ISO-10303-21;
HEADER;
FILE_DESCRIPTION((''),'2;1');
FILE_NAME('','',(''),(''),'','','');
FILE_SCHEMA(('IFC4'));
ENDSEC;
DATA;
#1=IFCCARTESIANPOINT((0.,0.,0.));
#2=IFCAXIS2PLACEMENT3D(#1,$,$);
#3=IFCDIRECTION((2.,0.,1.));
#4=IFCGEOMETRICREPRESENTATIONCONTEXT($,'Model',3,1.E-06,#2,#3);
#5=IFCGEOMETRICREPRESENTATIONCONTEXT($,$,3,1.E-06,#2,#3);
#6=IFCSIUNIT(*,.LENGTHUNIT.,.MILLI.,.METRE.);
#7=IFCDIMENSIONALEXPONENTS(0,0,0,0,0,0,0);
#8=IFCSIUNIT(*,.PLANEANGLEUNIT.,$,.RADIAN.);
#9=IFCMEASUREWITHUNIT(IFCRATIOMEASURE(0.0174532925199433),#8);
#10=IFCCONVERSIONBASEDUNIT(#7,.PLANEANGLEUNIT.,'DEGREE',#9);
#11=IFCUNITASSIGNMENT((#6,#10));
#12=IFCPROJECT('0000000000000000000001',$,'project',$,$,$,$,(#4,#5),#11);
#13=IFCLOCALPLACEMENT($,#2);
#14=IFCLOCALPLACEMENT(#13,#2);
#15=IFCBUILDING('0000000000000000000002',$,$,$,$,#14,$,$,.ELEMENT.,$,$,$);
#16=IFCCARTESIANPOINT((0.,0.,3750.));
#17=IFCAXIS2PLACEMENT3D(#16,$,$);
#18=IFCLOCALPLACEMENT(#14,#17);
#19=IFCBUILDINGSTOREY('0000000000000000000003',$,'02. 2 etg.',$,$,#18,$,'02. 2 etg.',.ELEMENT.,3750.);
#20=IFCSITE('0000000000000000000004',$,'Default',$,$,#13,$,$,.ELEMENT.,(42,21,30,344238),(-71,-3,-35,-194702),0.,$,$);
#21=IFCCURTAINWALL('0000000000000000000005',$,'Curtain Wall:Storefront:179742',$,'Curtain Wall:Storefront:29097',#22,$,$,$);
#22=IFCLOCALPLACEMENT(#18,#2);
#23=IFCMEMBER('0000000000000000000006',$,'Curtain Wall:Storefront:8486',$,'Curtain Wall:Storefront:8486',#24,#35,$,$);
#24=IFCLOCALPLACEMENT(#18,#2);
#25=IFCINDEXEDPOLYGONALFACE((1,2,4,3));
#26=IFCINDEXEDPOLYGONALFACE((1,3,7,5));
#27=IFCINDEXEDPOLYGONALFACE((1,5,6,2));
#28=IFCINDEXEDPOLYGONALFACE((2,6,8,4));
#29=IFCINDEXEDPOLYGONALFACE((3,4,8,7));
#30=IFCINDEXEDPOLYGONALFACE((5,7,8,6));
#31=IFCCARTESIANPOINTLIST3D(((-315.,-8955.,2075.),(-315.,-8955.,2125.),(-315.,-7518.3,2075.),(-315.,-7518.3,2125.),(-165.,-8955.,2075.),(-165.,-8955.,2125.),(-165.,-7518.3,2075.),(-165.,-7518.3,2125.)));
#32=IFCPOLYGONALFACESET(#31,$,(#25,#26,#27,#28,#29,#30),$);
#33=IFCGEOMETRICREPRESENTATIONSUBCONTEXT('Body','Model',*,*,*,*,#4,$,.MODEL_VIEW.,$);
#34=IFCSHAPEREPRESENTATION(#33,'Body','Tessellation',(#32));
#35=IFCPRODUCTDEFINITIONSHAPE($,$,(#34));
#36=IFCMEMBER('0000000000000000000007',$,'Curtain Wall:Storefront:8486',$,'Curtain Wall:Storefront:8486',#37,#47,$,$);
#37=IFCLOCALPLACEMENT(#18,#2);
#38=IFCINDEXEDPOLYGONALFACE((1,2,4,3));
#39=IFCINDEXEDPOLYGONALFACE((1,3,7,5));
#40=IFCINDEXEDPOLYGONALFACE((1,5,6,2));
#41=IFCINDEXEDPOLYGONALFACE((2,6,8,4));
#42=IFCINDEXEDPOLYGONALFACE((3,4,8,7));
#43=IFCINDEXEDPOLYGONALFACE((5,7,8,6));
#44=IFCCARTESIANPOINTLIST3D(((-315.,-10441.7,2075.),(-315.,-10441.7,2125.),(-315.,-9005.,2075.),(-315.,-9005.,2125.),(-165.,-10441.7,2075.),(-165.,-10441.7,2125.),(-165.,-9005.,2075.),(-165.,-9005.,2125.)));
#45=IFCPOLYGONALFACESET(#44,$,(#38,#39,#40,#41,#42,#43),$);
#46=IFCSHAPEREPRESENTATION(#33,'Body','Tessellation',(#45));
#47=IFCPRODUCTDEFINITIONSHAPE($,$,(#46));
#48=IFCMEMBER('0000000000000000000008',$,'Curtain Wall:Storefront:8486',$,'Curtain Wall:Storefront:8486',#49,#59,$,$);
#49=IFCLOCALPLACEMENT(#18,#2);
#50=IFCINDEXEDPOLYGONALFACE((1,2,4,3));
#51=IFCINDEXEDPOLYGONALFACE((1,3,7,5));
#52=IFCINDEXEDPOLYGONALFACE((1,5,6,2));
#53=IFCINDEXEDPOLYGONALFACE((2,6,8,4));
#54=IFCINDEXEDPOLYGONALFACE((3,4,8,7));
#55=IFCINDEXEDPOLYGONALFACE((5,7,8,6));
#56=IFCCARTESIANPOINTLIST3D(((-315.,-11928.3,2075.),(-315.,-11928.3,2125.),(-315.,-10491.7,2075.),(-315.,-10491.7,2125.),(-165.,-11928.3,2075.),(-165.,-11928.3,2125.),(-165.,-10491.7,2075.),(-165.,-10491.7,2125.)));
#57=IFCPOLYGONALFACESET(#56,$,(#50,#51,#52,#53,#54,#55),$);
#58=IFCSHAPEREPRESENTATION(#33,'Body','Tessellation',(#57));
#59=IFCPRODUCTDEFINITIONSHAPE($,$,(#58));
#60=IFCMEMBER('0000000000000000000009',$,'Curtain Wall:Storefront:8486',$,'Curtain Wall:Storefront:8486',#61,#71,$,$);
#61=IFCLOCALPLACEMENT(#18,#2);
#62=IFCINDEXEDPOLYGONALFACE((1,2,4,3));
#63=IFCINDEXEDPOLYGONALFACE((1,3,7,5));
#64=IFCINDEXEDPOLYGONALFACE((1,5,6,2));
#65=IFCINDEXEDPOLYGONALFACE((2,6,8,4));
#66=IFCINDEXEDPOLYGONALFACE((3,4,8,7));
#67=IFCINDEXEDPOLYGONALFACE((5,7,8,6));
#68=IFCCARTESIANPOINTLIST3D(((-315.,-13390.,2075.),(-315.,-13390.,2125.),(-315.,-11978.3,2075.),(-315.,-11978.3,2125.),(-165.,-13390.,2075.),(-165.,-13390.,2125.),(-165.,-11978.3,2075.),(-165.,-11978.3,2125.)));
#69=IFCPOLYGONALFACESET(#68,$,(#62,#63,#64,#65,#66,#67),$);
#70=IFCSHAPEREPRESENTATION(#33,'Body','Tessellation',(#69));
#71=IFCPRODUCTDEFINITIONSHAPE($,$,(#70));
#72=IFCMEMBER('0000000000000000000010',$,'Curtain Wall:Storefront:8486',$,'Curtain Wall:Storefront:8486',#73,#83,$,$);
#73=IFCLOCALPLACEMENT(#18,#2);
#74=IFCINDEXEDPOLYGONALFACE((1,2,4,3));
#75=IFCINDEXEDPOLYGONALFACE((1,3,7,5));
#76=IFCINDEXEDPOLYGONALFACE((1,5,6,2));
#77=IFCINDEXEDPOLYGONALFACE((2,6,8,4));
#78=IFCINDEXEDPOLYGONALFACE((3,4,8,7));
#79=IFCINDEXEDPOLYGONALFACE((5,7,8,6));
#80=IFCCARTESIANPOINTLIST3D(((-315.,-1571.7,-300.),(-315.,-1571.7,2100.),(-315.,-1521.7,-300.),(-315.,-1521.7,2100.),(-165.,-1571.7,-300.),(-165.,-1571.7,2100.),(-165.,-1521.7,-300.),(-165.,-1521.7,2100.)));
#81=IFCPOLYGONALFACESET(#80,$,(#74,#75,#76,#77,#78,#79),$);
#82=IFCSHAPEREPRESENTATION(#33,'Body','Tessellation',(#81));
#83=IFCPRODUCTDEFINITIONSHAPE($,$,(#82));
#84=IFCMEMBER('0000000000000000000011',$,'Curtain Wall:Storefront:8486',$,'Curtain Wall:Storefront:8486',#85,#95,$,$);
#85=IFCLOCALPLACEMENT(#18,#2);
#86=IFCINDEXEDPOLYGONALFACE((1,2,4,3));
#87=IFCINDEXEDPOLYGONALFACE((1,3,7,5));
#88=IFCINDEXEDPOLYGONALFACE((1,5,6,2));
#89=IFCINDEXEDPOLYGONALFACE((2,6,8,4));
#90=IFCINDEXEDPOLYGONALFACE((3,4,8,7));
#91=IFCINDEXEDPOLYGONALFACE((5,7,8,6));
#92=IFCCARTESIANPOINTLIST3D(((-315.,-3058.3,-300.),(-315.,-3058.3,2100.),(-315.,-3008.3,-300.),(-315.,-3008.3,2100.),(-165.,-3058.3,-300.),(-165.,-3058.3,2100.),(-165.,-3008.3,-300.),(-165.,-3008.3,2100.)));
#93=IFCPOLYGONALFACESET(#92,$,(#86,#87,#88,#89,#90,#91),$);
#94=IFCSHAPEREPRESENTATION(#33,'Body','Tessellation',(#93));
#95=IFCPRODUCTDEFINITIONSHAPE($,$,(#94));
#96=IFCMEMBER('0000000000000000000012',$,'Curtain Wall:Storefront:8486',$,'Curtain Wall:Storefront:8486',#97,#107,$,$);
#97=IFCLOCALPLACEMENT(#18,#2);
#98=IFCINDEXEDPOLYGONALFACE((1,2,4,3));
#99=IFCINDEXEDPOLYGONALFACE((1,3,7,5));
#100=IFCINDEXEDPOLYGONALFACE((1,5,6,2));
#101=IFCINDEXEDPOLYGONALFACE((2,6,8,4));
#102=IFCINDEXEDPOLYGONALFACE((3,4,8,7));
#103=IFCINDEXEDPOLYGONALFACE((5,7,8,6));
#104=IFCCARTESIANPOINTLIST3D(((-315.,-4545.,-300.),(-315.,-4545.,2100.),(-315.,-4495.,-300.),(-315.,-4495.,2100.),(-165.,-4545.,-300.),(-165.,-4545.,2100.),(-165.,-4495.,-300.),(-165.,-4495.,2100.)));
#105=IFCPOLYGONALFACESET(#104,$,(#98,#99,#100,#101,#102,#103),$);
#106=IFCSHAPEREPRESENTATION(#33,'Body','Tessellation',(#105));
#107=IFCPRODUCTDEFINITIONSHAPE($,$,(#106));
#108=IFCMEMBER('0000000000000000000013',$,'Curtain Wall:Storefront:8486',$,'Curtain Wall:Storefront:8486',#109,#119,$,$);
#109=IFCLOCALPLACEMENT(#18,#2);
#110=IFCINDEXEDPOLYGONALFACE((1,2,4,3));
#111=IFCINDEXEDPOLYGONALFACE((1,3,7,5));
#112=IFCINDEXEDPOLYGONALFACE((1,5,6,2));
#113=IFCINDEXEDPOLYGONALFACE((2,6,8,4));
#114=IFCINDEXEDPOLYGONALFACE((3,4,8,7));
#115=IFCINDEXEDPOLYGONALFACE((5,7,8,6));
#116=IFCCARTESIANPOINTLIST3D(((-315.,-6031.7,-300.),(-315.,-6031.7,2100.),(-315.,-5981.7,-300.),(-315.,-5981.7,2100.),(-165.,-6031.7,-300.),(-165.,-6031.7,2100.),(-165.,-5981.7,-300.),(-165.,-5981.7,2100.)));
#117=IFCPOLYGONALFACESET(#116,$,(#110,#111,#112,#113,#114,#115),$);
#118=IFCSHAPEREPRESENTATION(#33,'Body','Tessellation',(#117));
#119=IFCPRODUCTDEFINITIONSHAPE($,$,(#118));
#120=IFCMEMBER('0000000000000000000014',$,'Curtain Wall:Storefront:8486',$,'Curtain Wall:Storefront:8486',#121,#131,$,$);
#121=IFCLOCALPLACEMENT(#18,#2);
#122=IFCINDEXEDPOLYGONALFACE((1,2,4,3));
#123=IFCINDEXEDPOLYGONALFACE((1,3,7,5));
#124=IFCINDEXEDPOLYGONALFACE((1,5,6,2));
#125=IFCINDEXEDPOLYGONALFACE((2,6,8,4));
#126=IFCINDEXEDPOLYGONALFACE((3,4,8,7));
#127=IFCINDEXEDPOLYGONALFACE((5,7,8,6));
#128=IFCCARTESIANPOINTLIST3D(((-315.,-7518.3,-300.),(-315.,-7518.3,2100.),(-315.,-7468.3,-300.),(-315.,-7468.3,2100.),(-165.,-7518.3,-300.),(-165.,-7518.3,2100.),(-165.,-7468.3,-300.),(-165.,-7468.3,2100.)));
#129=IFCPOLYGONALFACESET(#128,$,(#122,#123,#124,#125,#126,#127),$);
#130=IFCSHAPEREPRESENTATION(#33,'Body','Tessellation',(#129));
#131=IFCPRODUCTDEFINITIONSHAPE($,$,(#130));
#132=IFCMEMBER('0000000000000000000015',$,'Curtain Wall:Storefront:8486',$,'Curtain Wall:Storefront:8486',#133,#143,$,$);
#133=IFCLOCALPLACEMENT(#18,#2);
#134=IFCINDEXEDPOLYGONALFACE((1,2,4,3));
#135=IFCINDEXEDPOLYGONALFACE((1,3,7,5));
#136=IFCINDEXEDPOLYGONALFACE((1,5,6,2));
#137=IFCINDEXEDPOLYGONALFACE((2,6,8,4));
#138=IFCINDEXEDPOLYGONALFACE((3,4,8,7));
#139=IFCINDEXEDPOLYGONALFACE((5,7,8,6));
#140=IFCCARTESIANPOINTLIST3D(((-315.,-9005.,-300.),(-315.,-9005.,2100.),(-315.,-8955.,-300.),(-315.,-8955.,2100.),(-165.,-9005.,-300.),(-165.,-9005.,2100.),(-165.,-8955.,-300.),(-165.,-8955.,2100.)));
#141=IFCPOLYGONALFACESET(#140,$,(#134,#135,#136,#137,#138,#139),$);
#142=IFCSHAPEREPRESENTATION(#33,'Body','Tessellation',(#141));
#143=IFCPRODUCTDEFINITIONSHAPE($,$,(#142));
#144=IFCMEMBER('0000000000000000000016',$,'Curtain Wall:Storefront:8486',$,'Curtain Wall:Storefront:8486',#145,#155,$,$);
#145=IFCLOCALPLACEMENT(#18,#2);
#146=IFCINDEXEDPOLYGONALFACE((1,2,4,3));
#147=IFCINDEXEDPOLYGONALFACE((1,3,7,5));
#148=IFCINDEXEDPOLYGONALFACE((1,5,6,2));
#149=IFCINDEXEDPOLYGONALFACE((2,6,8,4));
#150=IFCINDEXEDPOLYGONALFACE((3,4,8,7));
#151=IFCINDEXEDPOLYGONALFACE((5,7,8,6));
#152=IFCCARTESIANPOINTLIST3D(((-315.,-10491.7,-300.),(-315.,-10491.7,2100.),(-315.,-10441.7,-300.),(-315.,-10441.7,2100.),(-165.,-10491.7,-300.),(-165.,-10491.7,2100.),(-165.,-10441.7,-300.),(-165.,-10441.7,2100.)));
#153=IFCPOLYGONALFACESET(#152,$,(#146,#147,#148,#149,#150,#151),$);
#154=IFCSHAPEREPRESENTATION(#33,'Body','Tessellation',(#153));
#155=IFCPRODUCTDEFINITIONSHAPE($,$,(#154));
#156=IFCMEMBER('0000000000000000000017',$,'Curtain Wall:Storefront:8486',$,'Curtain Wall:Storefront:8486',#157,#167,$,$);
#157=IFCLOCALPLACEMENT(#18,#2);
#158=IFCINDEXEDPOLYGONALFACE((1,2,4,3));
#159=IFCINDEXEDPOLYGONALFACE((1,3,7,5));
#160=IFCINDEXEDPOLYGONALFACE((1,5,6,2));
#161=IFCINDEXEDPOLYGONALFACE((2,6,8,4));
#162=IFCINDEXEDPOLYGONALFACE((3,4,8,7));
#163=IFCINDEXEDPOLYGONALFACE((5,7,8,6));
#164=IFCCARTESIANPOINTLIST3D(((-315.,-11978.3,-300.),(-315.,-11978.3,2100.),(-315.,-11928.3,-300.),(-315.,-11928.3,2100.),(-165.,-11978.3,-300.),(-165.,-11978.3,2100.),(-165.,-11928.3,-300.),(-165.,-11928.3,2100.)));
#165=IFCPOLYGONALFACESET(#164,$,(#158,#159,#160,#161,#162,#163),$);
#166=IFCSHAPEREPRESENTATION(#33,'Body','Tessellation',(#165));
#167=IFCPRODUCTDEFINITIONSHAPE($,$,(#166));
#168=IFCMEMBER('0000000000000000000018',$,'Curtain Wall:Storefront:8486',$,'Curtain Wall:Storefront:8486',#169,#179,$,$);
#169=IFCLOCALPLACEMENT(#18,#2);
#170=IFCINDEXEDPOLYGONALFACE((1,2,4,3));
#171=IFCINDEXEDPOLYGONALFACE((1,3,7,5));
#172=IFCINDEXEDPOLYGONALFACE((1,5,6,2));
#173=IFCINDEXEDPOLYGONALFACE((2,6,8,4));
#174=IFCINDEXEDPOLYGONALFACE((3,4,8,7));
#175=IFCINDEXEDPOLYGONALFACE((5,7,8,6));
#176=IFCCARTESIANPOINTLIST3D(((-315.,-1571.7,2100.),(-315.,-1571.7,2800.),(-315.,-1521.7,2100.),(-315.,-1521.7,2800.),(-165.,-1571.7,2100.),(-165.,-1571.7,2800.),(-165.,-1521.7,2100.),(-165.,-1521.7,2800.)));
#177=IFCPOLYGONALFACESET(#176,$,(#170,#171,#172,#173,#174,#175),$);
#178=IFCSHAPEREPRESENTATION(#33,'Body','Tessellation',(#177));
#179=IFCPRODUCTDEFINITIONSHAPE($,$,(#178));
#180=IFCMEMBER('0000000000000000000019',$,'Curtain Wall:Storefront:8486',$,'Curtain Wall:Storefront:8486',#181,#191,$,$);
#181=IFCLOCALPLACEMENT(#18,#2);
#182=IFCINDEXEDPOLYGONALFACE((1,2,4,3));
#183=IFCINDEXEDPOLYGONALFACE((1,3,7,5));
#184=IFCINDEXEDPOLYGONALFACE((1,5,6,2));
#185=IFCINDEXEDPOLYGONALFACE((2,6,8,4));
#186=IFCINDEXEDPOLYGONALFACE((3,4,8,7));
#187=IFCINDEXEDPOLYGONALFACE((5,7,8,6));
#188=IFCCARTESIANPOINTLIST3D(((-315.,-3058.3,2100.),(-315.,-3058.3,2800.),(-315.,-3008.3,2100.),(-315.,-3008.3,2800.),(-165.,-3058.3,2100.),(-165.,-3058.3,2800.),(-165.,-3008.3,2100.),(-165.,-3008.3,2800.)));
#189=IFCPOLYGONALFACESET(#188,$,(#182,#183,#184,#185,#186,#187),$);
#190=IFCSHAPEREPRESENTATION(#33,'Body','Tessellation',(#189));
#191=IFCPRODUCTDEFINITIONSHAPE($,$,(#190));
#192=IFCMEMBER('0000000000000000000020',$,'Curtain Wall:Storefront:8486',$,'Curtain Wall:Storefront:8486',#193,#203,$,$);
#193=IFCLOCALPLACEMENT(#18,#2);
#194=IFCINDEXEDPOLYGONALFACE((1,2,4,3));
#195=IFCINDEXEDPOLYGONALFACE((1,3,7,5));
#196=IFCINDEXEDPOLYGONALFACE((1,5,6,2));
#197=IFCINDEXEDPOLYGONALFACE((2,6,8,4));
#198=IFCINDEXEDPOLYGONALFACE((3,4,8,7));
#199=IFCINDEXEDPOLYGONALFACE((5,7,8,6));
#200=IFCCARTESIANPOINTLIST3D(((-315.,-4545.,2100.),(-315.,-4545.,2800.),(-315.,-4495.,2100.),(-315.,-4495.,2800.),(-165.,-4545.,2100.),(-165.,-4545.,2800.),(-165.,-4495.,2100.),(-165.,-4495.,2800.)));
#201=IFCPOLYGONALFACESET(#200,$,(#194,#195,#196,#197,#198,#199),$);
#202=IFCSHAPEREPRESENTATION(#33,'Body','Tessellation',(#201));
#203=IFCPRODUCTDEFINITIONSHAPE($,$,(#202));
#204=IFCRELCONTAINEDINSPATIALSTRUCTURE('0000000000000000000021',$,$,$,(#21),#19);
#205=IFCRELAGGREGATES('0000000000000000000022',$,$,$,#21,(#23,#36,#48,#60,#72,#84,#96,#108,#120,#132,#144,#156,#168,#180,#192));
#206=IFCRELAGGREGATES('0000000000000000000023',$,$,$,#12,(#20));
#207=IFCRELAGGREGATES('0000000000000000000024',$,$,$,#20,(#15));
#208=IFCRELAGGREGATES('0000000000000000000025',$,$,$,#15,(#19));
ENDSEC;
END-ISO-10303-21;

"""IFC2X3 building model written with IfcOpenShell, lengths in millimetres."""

from ifc_helpers import new_model, entity, si_unit, converted_unit, direction, frame, frame_2d, origin, origin_2d_with_axis, place, context, subcontext, project, spatial, rectangle, extrude, element, aggregate, save


model = new_model("IFC2X3")

# Units and contexts
model_context = context("Model", 3, precision=1e-06, world=origin(), true_north=direction((2.0, 0.0, 1.0)))
context_of_model = context(None, 3, precision=1e-06, world=origin(), true_north=direction((2.0, 0.0, 1.0)))
body_context = subcontext(model_context, "Body", "Model", "MODEL_VIEW")
ifc_project = project(units=[si_unit("LENGTHUNIT", "METRE", prefix="MILLI"), converted_unit("PLANEANGLEUNIT", "DEGREE", entity("IfcRatioMeasure", 0.0174532925199433), si_unit("PLANEANGLEUNIT", "RADIAN"), dimensions=[0, 0, 0, 0, 0, 0, 0])], contexts=[model_context, context_of_model])

# Site, building, storey
site_placement = place(None, origin())
site = spatial("IfcSite", under=ifc_project, at=site_placement, Name="Default", CompositionType="ELEMENT", RefLatitude=(42, 21, 30, 344238), RefLongitude=(-71, -3, -35, -194702), RefElevation=0.0)
building_placement = place(site_placement, origin())
building = spatial("IfcBuilding", under=site, at=building_placement, CompositionType="ELEMENT")
storey_placement = place(building_placement, frame((0.0, 0.0, 3750.0)))
storey = spatial("IfcBuildingStorey", under=building, at=storey_placement, Name="02. 2 etg.", LongName="02. 2 etg.", CompositionType="ELEMENT", Elevation=3750.0)

# Curtain wall, members
curtain_wall_1_placement = place(storey_placement, origin())
curtain_wall_1 = element("IfcCurtainWall", 1, at=curtain_wall_1_placement, inside=storey, Name="Curtain Wall:Storefront:179742", ObjectType="Curtain Wall:Storefront:29097")
member_1_placement = place(storey_placement, origin())
member_1 = element("IfcMember", 2, at=member_1_placement, Name="Curtain Wall:Storefront:8486", ObjectType="Curtain Wall:Storefront:8486", context=body_context, shape_type="SweptSolid", body=[
    extrude(rectangle(XDim=1436.7, YDim=150.0, at=frame_2d((0.0, 0.0), x_axis=(1.0, 0.0))), frame((-240.0, -8236.7, 2075.0), z_axis=(0.0, 0.0, 1.0), x_axis=(0.0, 1.0, 0.0)), (0.0, 0.0, 1.0), 50.0),
])
member_2_placement = place(storey_placement, origin())
member_2 = element("IfcMember", 3, at=member_2_placement, Name="Curtain Wall:Storefront:8486", ObjectType="Curtain Wall:Storefront:8486", context=body_context, shape_type="SweptSolid", body=[
    extrude(rectangle(XDim=1436.7, YDim=150.0, at=origin_2d_with_axis()), frame((-240.0, -9723.3, 2075.0), z_axis=(0.0, 0.0, 1.0), x_axis=(0.0, 1.0, 0.0)), (0.0, 0.0, 1.0), 50.0),
])
member_3_placement = place(storey_placement, origin())
member_3 = element("IfcMember", 4, at=member_3_placement, Name="Curtain Wall:Storefront:8486", ObjectType="Curtain Wall:Storefront:8486", context=body_context, shape_type="SweptSolid", body=[
    extrude(rectangle(XDim=1436.7, YDim=150.0, at=origin_2d_with_axis()), frame((-240.0, -11210.0, 2075.0), z_axis=(0.0, 0.0, 1.0), x_axis=(0.0, 1.0, 0.0)), (0.0, 0.0, 1.0), 50.0),
])
member_4_placement = place(storey_placement, origin())
member_4 = element("IfcMember", 5, at=member_4_placement, Name="Curtain Wall:Storefront:8486", ObjectType="Curtain Wall:Storefront:8486", context=body_context, shape_type="SweptSolid", body=[
    extrude(rectangle(XDim=1411.7, YDim=150.0, at=frame_2d((0.0, 0.0), x_axis=(1.0, 0.0))), frame((-240.0, -12684.2, 2075.0), z_axis=(0.0, 0.0, 1.0), x_axis=(0.0, 1.0, 0.0)), (0.0, 0.0, 1.0), 50.0),
])
member_5_placement = place(storey_placement, origin())
member_5 = element("IfcMember", 6, at=member_5_placement, Name="Curtain Wall:Storefront:8486", ObjectType="Curtain Wall:Storefront:8486", context=body_context, shape_type="SweptSolid", body=[
    extrude(rectangle(XDim=150.0, YDim=50.0, at=frame_2d((0.0, 0.0), x_axis=(1.0, 0.0))), frame((-240.0, -1546.7, -300.0)), (0.0, 0.0, 1.0), 2400.0),
])
member_6_placement = place(storey_placement, origin())
member_6 = element("IfcMember", 7, at=member_6_placement, Name="Curtain Wall:Storefront:8486", ObjectType="Curtain Wall:Storefront:8486", context=body_context, shape_type="SweptSolid", body=[
    extrude(rectangle(XDim=150.0, YDim=50.0, at=frame_2d((0.0, 0.0), x_axis=(1.0, 0.0))), frame((-240.0, -3033.3, -300.0)), (0.0, 0.0, 1.0), 2400.0),
])
member_7_placement = place(storey_placement, origin())
member_7 = element("IfcMember", 8, at=member_7_placement, Name="Curtain Wall:Storefront:8486", ObjectType="Curtain Wall:Storefront:8486", context=body_context, shape_type="SweptSolid", body=[
    extrude(rectangle(XDim=150.0, YDim=50.0, at=frame_2d((0.0, 0.0), x_axis=(1.0, 0.0))), frame((-240.0, -4520.0, -300.0)), (0.0, 0.0, 1.0), 2400.0),
])
member_8_placement = place(storey_placement, origin())
member_8 = element("IfcMember", 9, at=member_8_placement, Name="Curtain Wall:Storefront:8486", ObjectType="Curtain Wall:Storefront:8486", context=body_context, shape_type="SweptSolid", body=[
    extrude(rectangle(XDim=150.0, YDim=50.0, at=frame_2d((0.0, 0.0), x_axis=(1.0, 0.0))), frame((-240.0, -6006.7, -300.0)), (0.0, 0.0, 1.0), 2400.0),
])
member_9_placement = place(storey_placement, origin())
member_9 = element("IfcMember", 10, at=member_9_placement, Name="Curtain Wall:Storefront:8486", ObjectType="Curtain Wall:Storefront:8486", context=body_context, shape_type="SweptSolid", body=[
    extrude(rectangle(XDim=150.0, YDim=50.0, at=frame_2d((0.0, 0.0), x_axis=(1.0, 0.0))), frame((-240.0, -7493.3, -300.0)), (0.0, 0.0, 1.0), 2400.0),
])
member_10_placement = place(storey_placement, origin())
member_10 = element("IfcMember", 11, at=member_10_placement, Name="Curtain Wall:Storefront:8486", ObjectType="Curtain Wall:Storefront:8486", context=body_context, shape_type="SweptSolid", body=[
    extrude(rectangle(XDim=150.0, YDim=50.0, at=frame_2d((0.0, 0.0), x_axis=(1.0, 0.0))), frame((-240.0, -8980.0, -300.0)), (0.0, 0.0, 1.0), 2400.0),
])
member_11_placement = place(storey_placement, origin())
member_11 = element("IfcMember", 12, at=member_11_placement, Name="Curtain Wall:Storefront:8486", ObjectType="Curtain Wall:Storefront:8486", context=body_context, shape_type="SweptSolid", body=[
    extrude(rectangle(XDim=150.0, YDim=50.0, at=frame_2d((0.0, 0.0), x_axis=(1.0, 0.0))), frame((-240.0, -10466.7, -300.0)), (0.0, 0.0, 1.0), 2400.0),
])
member_12_placement = place(storey_placement, origin())
member_12 = element("IfcMember", 13, at=member_12_placement, Name="Curtain Wall:Storefront:8486", ObjectType="Curtain Wall:Storefront:8486", context=body_context, shape_type="SweptSolid", body=[
    extrude(rectangle(XDim=150.0, YDim=50.0, at=frame_2d((0.0, 0.0), x_axis=(1.0, 0.0))), frame((-240.0, -11953.3, -300.0)), (0.0, 0.0, 1.0), 2400.0),
])
member_13_placement = place(storey_placement, origin())
member_13 = element("IfcMember", 14, at=member_13_placement, Name="Curtain Wall:Storefront:8486", ObjectType="Curtain Wall:Storefront:8486", context=body_context, shape_type="SweptSolid", body=[
    extrude(rectangle(XDim=150.0, YDim=50.0, at=frame_2d((0.0, 0.0), x_axis=(1.0, 0.0))), frame((-240.0, -1546.7, 2100.0)), (0.0, 0.0, 1.0), 700.0),
])
member_14_placement = place(storey_placement, origin())
member_14 = element("IfcMember", 15, at=member_14_placement, Name="Curtain Wall:Storefront:8486", ObjectType="Curtain Wall:Storefront:8486", context=body_context, shape_type="SweptSolid", body=[
    extrude(rectangle(XDim=150.0, YDim=50.0, at=frame_2d((0.0, 0.0), x_axis=(1.0, 0.0))), frame((-240.0, -3033.3, 2100.0)), (0.0, 0.0, 1.0), 700.0),
])
member_15_placement = place(storey_placement, origin())
member_15 = element("IfcMember", 16, at=member_15_placement, Name="Curtain Wall:Storefront:8486", ObjectType="Curtain Wall:Storefront:8486", context=body_context, shape_type="SweptSolid", body=[
    extrude(rectangle(XDim=150.0, YDim=50.0, at=frame_2d((0.0, 0.0), x_axis=(1.0, 0.0))), frame((-240.0, -4520.0, 2100.0)), (0.0, 0.0, 1.0), 700.0),
])
aggregate(curtain_wall_1, [member_1, member_2, member_3, member_4, member_5, member_6, member_7, member_8, member_9, member_10, member_11, member_12, member_13, member_14, member_15])

save(model, "model.ifc")
